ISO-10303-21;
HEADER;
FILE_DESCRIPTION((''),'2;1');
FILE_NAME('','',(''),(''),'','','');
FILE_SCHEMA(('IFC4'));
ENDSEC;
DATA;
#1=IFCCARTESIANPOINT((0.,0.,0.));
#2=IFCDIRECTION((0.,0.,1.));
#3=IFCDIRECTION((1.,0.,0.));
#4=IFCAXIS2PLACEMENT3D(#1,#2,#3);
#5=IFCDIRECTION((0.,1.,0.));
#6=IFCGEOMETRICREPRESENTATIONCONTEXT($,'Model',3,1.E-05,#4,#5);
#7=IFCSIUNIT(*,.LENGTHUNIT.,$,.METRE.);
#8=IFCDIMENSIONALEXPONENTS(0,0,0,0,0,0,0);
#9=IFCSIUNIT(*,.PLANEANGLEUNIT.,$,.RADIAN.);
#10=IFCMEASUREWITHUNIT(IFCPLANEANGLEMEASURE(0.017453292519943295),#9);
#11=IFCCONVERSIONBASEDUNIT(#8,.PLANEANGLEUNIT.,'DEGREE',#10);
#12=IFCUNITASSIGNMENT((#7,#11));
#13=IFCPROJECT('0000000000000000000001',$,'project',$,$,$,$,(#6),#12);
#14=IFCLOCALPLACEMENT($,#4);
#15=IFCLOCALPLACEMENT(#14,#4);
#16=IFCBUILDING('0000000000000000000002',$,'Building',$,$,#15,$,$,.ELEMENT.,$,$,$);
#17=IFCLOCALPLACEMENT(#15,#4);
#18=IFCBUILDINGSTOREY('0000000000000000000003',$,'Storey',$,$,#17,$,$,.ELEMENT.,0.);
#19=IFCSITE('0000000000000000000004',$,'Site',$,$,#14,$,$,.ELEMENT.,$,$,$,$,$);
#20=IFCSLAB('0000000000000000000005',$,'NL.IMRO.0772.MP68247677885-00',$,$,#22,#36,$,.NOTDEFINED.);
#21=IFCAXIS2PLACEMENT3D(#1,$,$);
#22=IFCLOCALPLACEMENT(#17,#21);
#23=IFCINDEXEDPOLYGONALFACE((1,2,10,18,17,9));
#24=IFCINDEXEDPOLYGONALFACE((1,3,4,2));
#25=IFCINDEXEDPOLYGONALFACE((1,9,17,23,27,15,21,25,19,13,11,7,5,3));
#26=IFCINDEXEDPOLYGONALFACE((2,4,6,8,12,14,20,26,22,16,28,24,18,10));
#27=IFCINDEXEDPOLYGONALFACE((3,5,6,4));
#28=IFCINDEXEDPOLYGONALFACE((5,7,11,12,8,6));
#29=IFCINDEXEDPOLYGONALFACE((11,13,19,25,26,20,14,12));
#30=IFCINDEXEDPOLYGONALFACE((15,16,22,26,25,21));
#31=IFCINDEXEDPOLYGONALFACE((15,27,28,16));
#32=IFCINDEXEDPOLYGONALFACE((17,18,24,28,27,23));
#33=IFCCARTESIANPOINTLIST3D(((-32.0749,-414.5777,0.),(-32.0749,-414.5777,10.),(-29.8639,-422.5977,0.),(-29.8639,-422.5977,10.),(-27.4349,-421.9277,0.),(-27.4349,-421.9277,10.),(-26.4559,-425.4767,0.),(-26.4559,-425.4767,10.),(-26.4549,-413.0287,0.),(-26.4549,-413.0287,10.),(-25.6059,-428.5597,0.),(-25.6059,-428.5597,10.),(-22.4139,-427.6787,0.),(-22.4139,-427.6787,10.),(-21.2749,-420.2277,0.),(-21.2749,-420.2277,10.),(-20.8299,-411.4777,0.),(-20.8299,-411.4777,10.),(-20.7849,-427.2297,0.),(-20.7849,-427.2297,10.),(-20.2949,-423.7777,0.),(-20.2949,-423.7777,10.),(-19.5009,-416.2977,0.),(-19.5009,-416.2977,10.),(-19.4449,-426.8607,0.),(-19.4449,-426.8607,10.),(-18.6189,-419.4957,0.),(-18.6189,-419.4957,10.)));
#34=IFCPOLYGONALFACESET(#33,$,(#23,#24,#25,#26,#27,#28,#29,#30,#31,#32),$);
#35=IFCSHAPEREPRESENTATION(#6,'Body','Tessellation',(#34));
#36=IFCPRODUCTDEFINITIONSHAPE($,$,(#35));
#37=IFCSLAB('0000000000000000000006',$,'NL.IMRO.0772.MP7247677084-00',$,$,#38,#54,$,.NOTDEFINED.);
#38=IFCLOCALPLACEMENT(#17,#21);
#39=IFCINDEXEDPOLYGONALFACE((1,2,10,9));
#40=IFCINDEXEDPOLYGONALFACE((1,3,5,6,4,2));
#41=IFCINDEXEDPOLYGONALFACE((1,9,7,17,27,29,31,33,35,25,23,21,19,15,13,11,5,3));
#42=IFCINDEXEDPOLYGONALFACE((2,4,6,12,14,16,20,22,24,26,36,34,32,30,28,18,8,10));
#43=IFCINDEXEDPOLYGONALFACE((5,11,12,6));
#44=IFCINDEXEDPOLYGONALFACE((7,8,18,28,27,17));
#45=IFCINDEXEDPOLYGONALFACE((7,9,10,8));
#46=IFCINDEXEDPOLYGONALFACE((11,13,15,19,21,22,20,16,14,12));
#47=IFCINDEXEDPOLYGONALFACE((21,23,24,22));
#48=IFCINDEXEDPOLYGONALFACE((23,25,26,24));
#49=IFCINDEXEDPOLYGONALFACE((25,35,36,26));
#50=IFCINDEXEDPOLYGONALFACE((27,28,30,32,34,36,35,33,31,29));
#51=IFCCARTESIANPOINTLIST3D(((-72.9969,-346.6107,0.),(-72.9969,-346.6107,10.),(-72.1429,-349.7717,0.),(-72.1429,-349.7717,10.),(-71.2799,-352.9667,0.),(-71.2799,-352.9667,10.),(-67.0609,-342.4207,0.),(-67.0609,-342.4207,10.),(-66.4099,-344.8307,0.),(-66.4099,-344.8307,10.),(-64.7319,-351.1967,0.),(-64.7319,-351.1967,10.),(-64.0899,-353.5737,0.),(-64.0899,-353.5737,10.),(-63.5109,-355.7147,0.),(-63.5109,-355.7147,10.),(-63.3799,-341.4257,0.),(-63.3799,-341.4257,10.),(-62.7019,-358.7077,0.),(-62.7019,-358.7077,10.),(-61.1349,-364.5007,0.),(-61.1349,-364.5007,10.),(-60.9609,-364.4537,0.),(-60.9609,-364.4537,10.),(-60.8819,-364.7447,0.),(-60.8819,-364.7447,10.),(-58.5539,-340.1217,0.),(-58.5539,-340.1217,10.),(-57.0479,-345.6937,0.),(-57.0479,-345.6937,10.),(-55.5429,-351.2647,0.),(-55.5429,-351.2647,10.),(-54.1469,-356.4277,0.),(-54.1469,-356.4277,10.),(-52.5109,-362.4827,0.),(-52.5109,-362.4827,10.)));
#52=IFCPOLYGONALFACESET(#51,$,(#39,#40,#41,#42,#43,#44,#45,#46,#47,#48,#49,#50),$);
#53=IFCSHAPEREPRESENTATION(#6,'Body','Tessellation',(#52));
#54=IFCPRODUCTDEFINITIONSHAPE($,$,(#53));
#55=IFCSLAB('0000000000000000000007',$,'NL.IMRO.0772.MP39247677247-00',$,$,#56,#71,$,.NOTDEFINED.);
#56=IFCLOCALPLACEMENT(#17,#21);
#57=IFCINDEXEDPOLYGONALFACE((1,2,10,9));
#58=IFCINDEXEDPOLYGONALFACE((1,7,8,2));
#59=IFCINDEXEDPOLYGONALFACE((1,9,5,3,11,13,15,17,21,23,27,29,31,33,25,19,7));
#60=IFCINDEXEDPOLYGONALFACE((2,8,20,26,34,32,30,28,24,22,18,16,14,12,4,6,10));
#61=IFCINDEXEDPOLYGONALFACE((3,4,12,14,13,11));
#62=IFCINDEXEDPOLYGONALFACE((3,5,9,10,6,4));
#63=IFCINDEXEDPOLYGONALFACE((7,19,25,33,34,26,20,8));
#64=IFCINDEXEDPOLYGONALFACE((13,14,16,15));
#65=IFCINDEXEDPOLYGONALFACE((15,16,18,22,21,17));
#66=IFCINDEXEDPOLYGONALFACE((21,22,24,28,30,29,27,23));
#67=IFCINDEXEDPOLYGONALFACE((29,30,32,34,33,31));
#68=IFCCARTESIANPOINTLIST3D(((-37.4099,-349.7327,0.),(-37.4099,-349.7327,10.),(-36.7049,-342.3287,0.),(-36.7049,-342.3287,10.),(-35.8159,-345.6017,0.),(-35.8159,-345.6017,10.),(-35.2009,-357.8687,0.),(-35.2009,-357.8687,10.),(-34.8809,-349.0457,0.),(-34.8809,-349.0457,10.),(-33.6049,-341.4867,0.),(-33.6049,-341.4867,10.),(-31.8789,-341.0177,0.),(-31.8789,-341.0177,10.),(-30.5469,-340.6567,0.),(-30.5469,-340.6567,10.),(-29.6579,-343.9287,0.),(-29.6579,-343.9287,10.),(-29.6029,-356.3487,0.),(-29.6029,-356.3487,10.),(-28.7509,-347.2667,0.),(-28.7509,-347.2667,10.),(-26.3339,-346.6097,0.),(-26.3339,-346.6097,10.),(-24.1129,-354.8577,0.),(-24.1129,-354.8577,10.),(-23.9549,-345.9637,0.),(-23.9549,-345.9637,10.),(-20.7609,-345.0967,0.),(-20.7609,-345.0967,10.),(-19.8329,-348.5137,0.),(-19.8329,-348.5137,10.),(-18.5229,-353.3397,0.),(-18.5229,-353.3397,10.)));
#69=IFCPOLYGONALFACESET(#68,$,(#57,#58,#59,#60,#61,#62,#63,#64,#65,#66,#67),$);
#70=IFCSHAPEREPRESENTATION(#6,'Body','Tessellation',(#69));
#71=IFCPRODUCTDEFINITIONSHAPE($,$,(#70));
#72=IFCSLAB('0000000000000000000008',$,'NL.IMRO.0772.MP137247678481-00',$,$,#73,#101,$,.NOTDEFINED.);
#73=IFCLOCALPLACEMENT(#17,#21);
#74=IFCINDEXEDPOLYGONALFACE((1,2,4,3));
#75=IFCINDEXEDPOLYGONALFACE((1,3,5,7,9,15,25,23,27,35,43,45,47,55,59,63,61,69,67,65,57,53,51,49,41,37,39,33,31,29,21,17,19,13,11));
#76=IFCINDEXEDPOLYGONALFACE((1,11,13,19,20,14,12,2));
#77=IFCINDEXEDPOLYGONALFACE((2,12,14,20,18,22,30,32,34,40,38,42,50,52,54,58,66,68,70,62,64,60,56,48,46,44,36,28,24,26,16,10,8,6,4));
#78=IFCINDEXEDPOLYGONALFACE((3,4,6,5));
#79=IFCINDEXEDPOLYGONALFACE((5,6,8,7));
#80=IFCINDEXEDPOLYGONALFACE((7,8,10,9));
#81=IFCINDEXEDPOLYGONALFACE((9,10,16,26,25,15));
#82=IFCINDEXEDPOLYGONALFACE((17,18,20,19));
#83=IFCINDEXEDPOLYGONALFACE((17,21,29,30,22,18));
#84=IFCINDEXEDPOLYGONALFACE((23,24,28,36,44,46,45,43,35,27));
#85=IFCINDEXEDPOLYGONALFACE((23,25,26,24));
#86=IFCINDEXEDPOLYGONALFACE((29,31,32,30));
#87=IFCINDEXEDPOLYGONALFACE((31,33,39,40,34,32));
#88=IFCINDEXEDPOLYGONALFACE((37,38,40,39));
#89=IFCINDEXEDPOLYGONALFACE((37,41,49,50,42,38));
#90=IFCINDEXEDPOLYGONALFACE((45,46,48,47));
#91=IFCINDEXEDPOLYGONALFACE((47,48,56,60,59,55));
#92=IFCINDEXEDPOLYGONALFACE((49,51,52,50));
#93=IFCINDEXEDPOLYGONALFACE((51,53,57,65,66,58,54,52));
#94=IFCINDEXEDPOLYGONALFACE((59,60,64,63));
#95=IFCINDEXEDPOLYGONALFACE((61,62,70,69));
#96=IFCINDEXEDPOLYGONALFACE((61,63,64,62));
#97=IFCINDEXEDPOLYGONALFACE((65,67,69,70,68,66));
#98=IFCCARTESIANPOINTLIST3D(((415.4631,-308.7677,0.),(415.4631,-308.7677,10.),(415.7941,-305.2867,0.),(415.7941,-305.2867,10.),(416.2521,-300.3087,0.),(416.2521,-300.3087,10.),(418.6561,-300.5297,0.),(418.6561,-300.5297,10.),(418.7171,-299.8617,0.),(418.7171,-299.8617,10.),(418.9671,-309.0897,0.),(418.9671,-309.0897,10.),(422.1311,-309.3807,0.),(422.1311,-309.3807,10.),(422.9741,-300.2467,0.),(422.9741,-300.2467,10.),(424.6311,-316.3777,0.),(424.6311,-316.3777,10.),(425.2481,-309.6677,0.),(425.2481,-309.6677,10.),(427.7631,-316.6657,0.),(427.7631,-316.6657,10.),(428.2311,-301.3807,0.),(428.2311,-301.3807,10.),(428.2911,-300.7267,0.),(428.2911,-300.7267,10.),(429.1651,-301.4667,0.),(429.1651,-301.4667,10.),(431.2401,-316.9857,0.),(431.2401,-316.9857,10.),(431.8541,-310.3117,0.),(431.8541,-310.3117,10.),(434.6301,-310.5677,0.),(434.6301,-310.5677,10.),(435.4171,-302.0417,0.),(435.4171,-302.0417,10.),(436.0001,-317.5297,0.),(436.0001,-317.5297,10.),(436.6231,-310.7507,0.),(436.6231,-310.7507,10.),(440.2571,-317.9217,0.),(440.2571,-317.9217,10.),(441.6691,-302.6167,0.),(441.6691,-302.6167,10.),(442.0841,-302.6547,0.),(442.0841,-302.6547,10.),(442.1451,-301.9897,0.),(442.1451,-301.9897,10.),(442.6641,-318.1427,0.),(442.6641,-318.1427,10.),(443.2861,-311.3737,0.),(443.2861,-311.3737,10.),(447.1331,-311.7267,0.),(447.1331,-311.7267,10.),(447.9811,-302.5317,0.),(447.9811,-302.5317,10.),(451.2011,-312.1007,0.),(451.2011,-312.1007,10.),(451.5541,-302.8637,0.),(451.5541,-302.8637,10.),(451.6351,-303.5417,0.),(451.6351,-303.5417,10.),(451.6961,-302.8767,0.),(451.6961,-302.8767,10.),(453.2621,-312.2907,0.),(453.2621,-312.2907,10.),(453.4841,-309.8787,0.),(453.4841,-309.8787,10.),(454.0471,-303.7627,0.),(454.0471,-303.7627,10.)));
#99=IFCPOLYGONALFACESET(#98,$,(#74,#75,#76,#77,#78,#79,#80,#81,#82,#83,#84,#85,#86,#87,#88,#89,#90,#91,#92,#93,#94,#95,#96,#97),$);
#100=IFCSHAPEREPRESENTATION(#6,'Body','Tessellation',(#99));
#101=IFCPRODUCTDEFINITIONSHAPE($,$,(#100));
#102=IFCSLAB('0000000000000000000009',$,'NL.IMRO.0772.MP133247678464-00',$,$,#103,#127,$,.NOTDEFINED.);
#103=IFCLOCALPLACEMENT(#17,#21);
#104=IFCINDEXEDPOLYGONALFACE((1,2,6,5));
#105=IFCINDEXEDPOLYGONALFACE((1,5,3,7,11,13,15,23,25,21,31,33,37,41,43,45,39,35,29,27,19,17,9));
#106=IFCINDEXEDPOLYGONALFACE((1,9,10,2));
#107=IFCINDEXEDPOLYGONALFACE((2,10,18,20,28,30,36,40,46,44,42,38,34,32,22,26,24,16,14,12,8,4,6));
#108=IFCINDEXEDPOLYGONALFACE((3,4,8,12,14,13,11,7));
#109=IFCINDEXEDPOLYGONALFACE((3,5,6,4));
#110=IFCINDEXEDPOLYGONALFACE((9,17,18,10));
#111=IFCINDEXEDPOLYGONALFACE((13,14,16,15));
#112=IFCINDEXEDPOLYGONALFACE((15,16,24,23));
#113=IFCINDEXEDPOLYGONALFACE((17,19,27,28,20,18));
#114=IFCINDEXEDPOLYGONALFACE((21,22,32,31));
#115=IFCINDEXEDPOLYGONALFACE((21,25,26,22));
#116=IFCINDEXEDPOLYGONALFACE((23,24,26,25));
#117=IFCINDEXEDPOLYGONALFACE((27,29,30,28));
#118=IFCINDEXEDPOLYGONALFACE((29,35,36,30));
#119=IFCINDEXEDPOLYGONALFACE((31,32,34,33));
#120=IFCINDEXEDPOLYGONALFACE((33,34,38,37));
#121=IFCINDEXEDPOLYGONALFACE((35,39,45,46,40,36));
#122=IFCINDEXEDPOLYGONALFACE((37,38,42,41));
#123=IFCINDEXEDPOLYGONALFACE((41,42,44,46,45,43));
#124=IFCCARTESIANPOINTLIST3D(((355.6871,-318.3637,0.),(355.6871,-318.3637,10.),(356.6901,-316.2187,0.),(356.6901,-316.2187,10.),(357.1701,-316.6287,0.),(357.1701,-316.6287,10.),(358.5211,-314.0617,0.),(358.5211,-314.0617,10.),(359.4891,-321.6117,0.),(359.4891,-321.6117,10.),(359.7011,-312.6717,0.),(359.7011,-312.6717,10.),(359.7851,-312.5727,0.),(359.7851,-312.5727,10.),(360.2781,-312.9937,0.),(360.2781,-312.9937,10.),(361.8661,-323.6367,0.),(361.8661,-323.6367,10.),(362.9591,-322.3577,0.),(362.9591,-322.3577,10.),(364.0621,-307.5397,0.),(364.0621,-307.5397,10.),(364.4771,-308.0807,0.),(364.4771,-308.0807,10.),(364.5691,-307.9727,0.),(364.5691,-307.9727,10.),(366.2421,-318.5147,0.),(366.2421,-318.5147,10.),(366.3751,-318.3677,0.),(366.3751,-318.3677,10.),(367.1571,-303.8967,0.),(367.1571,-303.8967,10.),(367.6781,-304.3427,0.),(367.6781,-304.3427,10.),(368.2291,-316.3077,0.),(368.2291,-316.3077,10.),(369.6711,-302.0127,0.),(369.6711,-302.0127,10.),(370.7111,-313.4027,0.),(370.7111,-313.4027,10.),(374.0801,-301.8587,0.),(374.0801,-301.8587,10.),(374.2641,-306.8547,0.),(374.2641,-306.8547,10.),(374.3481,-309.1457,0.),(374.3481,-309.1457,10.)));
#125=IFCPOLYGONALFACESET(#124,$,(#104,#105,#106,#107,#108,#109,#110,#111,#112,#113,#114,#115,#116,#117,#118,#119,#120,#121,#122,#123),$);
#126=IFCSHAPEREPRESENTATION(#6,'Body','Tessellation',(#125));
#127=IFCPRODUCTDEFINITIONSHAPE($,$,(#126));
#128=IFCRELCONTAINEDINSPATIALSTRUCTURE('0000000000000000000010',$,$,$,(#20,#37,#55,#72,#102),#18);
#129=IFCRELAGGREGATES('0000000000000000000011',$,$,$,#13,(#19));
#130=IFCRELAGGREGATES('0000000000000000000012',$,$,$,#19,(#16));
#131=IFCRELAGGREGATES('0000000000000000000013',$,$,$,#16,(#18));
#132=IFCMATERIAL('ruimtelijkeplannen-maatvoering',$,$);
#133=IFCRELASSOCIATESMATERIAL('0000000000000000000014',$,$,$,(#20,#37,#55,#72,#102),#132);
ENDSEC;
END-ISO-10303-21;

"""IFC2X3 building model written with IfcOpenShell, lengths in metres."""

from ifc_helpers import new_model, entity, si_unit, converted_unit, direction, origin_with_axes, place, context, project, spatial, polyline, outline, extrude, material, element, save


model = new_model("IFC2X3")

# Units and contexts
model_context = context("Model", 3, precision=1e-05, world=origin_with_axes(), true_north=direction((0.0, 1.0, 0.0)))
ifc_project = project(units=[si_unit("LENGTHUNIT", "METRE"), converted_unit("PLANEANGLEUNIT", "DEGREE", entity("IfcPlaneAngleMeasure", 0.017453292519943295), si_unit("PLANEANGLEUNIT", "RADIAN"), dimensions=[0, 0, 0, 0, 0, 0, 0])], contexts=[model_context])

# Site, building, storey
site_placement = place(None, origin_with_axes())
site = spatial("IfcSite", under=ifc_project, at=site_placement, Name="Site", CompositionType="ELEMENT")
building_placement = place(site_placement, origin_with_axes())
building = spatial("IfcBuilding", under=site, at=building_placement, Name="Building", CompositionType="ELEMENT")
storey_placement = place(building_placement, origin_with_axes())
storey = spatial("IfcBuildingStorey", under=building, at=storey_placement, Name="Storey", CompositionType="ELEMENT", Elevation=0.0)

# Slabs
ifc_material = material(Name="ruimtelijkeplannen-maatvoering")
slab_1_placement = place(storey_placement, origin_with_axes())
element("IfcSlab", 1, at=slab_1_placement, inside=storey, material=ifc_material, Name="NL.IMRO.0772.MP68247677885-00", PredefinedType="NOTDEFINED", context=model_context, shape_type="SweptSolid", body=[
    extrude(outline(polyline([(-18.6189, -419.4957), (-21.2749, -420.2277), (-20.2949, -423.7777), (-19.4449, -426.8607), (-20.7849, -427.2297), (-22.4139, -427.6787), (-25.6059, -428.5597), (-26.4559, -425.4767), (-27.4349, -421.9277), (-29.8639, -422.5977), (-32.0749, -414.5777), (-26.4549, -413.0287), (-20.8299, -411.4777), (-19.5009, -416.2977), (-18.6189, -419.4957)])), origin_with_axes(), (0.0, 0.0, 1.0), 10.0),
])
slab_2_placement = place(storey_placement, origin_with_axes())
element("IfcSlab", 2, at=slab_2_placement, inside=storey, material=ifc_material, Name="NL.IMRO.0772.MP7247677084-00", PredefinedType="NOTDEFINED", context=model_context, shape_type="SweptSolid", body=[
    extrude(outline(polyline([(-64.7319, -351.1967), (-71.2799, -352.9667), (-72.1429, -349.7717), (-72.9969, -346.6107), (-66.4099, -344.8307), (-67.0609, -342.4207), (-63.3799, -341.4257), (-58.5539, -340.1217), (-57.0479, -345.6937), (-55.5429, -351.2647), (-54.1469, -356.4277), (-52.5109, -362.4827), (-60.8819, -364.7447), (-60.9609, -364.4537), (-61.1349, -364.5007), (-62.7019, -358.7077), (-63.5109, -355.7147), (-64.0899, -353.5737), (-64.7319, -351.1967)])), origin_with_axes(), (0.0, 0.0, 1.0), 10.0),
])
slab_3_placement = place(storey_placement, origin_with_axes())
element("IfcSlab", 3, at=slab_3_placement, inside=storey, material=ifc_material, Name="NL.IMRO.0772.MP39247677247-00", PredefinedType="NOTDEFINED", context=model_context, shape_type="SweptSolid", body=[
    extrude(outline(polyline([(-20.7609, -345.0967), (-19.8329, -348.5137), (-18.5229, -353.3397), (-24.1129, -354.8577), (-29.6029, -356.3487), (-35.2009, -357.8687), (-37.4099, -349.7327), (-34.8809, -349.0457), (-35.8159, -345.6017), (-36.7049, -342.3287), (-33.6049, -341.4867), (-31.8789, -341.0177), (-30.5469, -340.6567), (-29.6579, -343.9287), (-28.7509, -347.2667), (-26.3339, -346.6097), (-23.9549, -345.9637), (-20.7609, -345.0967)])), origin_with_axes(), (0.0, 0.0, 1.0), 10.0),
])
slab_4_placement = place(storey_placement, origin_with_axes())
element("IfcSlab", 4, at=slab_4_placement, inside=storey, material=ifc_material, Name="NL.IMRO.0772.MP137247678481-00", PredefinedType="NOTDEFINED", context=model_context, shape_type="SweptSolid", body=[
    extrude(outline(polyline([(451.6351, -303.5417), (454.0471, -303.7627), (453.4841, -309.8787), (453.2621, -312.2907), (451.2011, -312.1007), (447.1331, -311.7267), (443.2861, -311.3737), (442.6641, -318.1427), (440.2571, -317.9217), (436.0001, -317.5297), (436.6231, -310.7507), (434.6301, -310.5677), (431.8541, -310.3117), (431.2401, -316.9857), (427.7631, -316.6657), (424.6311, -316.3777), (425.2481, -309.6677), (422.1311, -309.3807), (418.9671, -309.0897), (415.4631, -308.7677), (415.7941, -305.2867), (416.2521, -300.3087), (418.6561, -300.5297), (418.7171, -299.8617), (422.9741, -300.2467), (428.2911, -300.7267), (428.2311, -301.3807), (429.1651, -301.4667), (435.4171, -302.0417), (441.6691, -302.6167), (442.0841, -302.6547), (442.1451, -301.9897), (447.9811, -302.5317), (451.5541, -302.8637), (451.6961, -302.8767), (451.6351, -303.5417)])), origin_with_axes(), (0.0, 0.0, 1.0), 10.0),
])
slab_5_placement = place(storey_placement, origin_with_axes())
element("IfcSlab", 5, at=slab_5_placement, inside=storey, material=ifc_material, Name="NL.IMRO.0772.MP133247678464-00", PredefinedType="NOTDEFINED", context=model_context, shape_type="SweptSolid", body=[
    extrude(outline(polyline([(366.2421, -318.5147), (362.9591, -322.3577), (361.8661, -323.6367), (359.4891, -321.6117), (355.6871, -318.3637), (357.1701, -316.6287), (356.6901, -316.2187), (358.5211, -314.0617), (359.7011, -312.6717), (359.7851, -312.5727), (360.2781, -312.9937), (364.4771, -308.0807), (364.5691, -307.9727), (364.0621, -307.5397), (367.1571, -303.8967), (367.6781, -304.3427), (369.6711, -302.0127), (374.0801, -301.8587), (374.2641, -306.8547), (374.3481, -309.1457), (370.7111, -313.4027), (368.2291, -316.3077), (366.3751, -318.3677), (366.2421, -318.5147)])), origin_with_axes(), (0.0, 0.0, 1.0), 10.0),
])

save(model, "model.ifc")
